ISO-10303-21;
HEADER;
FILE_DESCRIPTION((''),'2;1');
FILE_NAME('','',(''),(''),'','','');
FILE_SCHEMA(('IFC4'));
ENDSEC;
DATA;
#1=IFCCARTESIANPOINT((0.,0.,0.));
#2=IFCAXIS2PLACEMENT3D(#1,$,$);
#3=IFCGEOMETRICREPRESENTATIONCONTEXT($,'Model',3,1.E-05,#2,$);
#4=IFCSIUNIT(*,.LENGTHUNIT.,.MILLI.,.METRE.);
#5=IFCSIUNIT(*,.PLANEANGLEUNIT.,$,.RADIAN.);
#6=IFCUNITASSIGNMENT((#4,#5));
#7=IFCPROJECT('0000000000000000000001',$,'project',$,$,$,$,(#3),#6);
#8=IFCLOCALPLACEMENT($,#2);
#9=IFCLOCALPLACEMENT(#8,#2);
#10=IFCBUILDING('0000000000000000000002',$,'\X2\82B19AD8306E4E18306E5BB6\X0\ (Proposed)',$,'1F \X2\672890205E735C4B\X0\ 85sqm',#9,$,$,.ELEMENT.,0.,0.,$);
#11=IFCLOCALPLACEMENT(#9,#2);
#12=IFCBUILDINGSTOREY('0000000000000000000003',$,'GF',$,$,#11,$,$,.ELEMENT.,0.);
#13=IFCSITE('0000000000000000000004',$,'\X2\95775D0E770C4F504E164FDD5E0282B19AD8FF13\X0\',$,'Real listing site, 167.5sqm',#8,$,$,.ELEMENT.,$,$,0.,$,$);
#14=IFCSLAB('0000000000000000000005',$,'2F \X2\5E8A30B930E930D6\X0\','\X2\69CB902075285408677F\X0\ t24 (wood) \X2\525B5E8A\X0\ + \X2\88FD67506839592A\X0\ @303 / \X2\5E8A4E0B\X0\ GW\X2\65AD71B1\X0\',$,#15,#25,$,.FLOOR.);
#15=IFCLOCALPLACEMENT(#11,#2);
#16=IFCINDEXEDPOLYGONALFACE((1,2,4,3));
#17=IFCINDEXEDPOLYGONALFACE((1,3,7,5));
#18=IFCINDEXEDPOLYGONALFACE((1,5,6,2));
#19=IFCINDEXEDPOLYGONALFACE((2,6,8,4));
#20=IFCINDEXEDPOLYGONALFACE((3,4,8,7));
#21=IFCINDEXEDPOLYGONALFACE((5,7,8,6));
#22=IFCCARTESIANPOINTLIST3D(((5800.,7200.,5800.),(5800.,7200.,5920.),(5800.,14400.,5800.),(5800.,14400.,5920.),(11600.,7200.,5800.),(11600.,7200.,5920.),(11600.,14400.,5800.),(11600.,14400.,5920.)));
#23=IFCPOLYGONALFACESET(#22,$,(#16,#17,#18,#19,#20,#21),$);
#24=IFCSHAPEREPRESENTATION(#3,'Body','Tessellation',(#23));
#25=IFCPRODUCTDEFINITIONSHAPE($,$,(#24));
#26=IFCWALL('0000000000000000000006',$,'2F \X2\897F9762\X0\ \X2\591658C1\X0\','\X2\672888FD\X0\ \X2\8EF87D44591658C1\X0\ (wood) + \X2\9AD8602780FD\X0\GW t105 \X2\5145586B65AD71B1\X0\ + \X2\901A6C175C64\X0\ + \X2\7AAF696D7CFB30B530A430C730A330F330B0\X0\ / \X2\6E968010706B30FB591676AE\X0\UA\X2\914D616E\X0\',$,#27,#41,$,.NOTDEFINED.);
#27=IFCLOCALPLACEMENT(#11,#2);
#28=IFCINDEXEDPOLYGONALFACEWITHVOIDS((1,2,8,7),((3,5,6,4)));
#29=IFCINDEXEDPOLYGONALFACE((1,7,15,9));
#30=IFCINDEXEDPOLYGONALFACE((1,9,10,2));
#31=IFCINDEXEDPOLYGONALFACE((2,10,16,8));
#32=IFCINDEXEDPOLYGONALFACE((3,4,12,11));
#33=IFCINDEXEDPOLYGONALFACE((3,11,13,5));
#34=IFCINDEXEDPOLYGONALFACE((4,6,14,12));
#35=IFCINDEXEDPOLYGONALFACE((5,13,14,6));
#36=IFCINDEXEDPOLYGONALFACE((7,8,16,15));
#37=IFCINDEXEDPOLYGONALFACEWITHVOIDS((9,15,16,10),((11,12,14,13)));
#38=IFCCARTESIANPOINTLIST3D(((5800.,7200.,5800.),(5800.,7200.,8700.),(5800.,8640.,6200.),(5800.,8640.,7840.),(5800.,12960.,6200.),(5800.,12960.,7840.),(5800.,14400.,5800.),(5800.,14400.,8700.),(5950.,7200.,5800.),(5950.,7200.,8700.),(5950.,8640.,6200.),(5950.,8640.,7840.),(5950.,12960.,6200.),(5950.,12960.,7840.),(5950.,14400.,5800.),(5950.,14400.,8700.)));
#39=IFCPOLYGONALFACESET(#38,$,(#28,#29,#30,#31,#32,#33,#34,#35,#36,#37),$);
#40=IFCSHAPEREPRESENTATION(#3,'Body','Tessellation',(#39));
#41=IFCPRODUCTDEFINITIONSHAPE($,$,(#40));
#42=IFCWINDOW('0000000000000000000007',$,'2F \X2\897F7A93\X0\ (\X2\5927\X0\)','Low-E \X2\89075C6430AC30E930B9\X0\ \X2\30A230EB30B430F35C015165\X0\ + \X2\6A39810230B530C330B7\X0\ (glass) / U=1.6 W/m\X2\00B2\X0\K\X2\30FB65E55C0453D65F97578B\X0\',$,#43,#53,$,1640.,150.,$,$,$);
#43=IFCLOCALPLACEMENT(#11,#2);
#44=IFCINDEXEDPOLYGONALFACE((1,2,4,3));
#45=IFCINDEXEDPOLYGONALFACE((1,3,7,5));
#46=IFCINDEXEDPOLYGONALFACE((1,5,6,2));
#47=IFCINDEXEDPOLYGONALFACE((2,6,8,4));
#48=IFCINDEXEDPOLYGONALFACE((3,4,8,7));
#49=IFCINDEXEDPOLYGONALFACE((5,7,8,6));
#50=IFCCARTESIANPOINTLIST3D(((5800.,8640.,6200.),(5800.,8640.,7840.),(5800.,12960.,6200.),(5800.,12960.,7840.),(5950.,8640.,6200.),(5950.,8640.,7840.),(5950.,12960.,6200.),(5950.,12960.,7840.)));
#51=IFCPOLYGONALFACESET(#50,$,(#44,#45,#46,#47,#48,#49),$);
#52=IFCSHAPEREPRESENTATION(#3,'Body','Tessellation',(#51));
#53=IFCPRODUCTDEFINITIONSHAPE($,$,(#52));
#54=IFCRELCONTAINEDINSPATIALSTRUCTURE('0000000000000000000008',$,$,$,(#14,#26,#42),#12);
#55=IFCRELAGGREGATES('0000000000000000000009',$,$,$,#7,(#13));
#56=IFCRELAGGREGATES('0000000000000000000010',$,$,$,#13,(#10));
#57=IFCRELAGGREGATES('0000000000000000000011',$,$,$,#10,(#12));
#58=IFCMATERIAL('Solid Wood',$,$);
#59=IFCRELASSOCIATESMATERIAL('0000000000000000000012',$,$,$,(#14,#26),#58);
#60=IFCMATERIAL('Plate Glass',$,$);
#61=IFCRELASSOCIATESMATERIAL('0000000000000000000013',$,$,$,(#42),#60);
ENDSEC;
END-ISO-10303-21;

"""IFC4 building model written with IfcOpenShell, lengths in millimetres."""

from ifc_helpers import new_model, si_unit, frame, frame_2d, origin, place, context, project, spatial, rectangle, extrude, material, element, fill, save


model = new_model("IFC4")

# Units and contexts
model_context = context("Model", 3, precision=1e-05, world=origin())
ifc_project = project(units=[si_unit("LENGTHUNIT", "METRE", prefix="MILLI"), si_unit("PLANEANGLEUNIT", "RADIAN")], contexts=[model_context])

# Site, building, storey
site_placement = place(None, origin())
site = spatial("IfcSite", under=ifc_project, at=site_placement, Name="長崎県佐世保市花高３", ObjectType="Real listing site, 167.5sqm", CompositionType="ELEMENT", RefElevation=0.0)
building_placement = place(site_placement, origin())
building = spatial("IfcBuilding", under=site, at=building_placement, Name="花高の丘の家 (Proposed)", ObjectType="1F 木造平屋 85sqm", CompositionType="ELEMENT", ElevationOfRefHeight=0.0, ElevationOfTerrain=0.0)
storey_placement = place(building_placement, origin())
storey = spatial("IfcBuildingStorey", under=building, at=storey_placement, Name="GF", CompositionType="ELEMENT", Elevation=0.0)

# Slab
ifc_material_1 = material(Name="Solid Wood")
slab_placement = place(storey_placement, frame((2900.0, 3600.0, 2900.0)))
element("IfcSlab", 1, at=slab_placement, inside=storey, material=ifc_material_1, Name="2F 床スラブ", Description="構造用合板 t24 (wood) 剛床 + 製材根太 @303 / 床下 GW断熱", PredefinedType="FLOOR", context=model_context, shape_type="SweptSolid", body=[
    extrude(rectangle(XDim=5800.0, YDim=7200.0, at=frame_2d((2900.0, 3600.0))), frame((2900.0, 3600.0, 2900.0)), (0.0, 0.0, 1.0), 120.0),
])

# Shared definitions
ifc_material_2 = material(Name="Plate Glass")

# Wall, opening, window
wall_1_placement = place(storey_placement, frame((2900.0, 3600.0, 2900.0)))
wall_1 = element("IfcWall", 2, at=wall_1_placement, inside=storey, material=ifc_material_1, Name="2F 西面 外壁", Description="木製 軸組外壁 (wood) + 高性能GW t105 充填断熱 + 通気層 + 窯業系サイディング / 準耐火・外皮UA配慮", PredefinedType="NOTDEFINED", context=model_context, shape_type="SweptSolid", body=[
    extrude(rectangle(XDim=150.0, YDim=7200.0, at=frame_2d((75.0, 3600.0))), frame((2900.0, 3600.0, 2900.0)), (0.0, 0.0, 1.0), 2900.0),
])
opening_1_placement = place(storey_placement, frame((2900.0, 4320.0, 3100.0)))
opening_1 = element("IfcOpeningElement", 3, at=opening_1_placement, cuts=wall_1, PredefinedType="NOTDEFINED", context=model_context, shape_type="SweptSolid", body=[
    extrude(rectangle(XDim=150.0, YDim=4320.0, at=frame_2d((75.0, 2160.0))), frame((2900.0, 4320.0, 3100.0)), (0.0, 0.0, 1.0), 1640.0),
])
window_1_placement = place(storey_placement, frame((2900.0, 4320.0, 3100.0)))
window_1 = element("IfcWindow", 4, at=window_1_placement, inside=storey, material=ifc_material_2, Name="2F 西窓 (大)", Description="Low-E 複層ガラス アルゴン封入 + 樹脂サッシ (glass) / U=1.6 W/m²K・日射取得型", OverallHeight=1640.0, OverallWidth=150.0, context=model_context, shape_type="SweptSolid", body=[
    extrude(rectangle(XDim=150.0, YDim=4320.0, at=frame_2d((75.0, 2160.0))), frame((2900.0, 4320.0, 3100.0)), (0.0, 0.0, 1.0), 1640.0),
])
fill(opening_1, window_1)

save(model, "model.ifc")
